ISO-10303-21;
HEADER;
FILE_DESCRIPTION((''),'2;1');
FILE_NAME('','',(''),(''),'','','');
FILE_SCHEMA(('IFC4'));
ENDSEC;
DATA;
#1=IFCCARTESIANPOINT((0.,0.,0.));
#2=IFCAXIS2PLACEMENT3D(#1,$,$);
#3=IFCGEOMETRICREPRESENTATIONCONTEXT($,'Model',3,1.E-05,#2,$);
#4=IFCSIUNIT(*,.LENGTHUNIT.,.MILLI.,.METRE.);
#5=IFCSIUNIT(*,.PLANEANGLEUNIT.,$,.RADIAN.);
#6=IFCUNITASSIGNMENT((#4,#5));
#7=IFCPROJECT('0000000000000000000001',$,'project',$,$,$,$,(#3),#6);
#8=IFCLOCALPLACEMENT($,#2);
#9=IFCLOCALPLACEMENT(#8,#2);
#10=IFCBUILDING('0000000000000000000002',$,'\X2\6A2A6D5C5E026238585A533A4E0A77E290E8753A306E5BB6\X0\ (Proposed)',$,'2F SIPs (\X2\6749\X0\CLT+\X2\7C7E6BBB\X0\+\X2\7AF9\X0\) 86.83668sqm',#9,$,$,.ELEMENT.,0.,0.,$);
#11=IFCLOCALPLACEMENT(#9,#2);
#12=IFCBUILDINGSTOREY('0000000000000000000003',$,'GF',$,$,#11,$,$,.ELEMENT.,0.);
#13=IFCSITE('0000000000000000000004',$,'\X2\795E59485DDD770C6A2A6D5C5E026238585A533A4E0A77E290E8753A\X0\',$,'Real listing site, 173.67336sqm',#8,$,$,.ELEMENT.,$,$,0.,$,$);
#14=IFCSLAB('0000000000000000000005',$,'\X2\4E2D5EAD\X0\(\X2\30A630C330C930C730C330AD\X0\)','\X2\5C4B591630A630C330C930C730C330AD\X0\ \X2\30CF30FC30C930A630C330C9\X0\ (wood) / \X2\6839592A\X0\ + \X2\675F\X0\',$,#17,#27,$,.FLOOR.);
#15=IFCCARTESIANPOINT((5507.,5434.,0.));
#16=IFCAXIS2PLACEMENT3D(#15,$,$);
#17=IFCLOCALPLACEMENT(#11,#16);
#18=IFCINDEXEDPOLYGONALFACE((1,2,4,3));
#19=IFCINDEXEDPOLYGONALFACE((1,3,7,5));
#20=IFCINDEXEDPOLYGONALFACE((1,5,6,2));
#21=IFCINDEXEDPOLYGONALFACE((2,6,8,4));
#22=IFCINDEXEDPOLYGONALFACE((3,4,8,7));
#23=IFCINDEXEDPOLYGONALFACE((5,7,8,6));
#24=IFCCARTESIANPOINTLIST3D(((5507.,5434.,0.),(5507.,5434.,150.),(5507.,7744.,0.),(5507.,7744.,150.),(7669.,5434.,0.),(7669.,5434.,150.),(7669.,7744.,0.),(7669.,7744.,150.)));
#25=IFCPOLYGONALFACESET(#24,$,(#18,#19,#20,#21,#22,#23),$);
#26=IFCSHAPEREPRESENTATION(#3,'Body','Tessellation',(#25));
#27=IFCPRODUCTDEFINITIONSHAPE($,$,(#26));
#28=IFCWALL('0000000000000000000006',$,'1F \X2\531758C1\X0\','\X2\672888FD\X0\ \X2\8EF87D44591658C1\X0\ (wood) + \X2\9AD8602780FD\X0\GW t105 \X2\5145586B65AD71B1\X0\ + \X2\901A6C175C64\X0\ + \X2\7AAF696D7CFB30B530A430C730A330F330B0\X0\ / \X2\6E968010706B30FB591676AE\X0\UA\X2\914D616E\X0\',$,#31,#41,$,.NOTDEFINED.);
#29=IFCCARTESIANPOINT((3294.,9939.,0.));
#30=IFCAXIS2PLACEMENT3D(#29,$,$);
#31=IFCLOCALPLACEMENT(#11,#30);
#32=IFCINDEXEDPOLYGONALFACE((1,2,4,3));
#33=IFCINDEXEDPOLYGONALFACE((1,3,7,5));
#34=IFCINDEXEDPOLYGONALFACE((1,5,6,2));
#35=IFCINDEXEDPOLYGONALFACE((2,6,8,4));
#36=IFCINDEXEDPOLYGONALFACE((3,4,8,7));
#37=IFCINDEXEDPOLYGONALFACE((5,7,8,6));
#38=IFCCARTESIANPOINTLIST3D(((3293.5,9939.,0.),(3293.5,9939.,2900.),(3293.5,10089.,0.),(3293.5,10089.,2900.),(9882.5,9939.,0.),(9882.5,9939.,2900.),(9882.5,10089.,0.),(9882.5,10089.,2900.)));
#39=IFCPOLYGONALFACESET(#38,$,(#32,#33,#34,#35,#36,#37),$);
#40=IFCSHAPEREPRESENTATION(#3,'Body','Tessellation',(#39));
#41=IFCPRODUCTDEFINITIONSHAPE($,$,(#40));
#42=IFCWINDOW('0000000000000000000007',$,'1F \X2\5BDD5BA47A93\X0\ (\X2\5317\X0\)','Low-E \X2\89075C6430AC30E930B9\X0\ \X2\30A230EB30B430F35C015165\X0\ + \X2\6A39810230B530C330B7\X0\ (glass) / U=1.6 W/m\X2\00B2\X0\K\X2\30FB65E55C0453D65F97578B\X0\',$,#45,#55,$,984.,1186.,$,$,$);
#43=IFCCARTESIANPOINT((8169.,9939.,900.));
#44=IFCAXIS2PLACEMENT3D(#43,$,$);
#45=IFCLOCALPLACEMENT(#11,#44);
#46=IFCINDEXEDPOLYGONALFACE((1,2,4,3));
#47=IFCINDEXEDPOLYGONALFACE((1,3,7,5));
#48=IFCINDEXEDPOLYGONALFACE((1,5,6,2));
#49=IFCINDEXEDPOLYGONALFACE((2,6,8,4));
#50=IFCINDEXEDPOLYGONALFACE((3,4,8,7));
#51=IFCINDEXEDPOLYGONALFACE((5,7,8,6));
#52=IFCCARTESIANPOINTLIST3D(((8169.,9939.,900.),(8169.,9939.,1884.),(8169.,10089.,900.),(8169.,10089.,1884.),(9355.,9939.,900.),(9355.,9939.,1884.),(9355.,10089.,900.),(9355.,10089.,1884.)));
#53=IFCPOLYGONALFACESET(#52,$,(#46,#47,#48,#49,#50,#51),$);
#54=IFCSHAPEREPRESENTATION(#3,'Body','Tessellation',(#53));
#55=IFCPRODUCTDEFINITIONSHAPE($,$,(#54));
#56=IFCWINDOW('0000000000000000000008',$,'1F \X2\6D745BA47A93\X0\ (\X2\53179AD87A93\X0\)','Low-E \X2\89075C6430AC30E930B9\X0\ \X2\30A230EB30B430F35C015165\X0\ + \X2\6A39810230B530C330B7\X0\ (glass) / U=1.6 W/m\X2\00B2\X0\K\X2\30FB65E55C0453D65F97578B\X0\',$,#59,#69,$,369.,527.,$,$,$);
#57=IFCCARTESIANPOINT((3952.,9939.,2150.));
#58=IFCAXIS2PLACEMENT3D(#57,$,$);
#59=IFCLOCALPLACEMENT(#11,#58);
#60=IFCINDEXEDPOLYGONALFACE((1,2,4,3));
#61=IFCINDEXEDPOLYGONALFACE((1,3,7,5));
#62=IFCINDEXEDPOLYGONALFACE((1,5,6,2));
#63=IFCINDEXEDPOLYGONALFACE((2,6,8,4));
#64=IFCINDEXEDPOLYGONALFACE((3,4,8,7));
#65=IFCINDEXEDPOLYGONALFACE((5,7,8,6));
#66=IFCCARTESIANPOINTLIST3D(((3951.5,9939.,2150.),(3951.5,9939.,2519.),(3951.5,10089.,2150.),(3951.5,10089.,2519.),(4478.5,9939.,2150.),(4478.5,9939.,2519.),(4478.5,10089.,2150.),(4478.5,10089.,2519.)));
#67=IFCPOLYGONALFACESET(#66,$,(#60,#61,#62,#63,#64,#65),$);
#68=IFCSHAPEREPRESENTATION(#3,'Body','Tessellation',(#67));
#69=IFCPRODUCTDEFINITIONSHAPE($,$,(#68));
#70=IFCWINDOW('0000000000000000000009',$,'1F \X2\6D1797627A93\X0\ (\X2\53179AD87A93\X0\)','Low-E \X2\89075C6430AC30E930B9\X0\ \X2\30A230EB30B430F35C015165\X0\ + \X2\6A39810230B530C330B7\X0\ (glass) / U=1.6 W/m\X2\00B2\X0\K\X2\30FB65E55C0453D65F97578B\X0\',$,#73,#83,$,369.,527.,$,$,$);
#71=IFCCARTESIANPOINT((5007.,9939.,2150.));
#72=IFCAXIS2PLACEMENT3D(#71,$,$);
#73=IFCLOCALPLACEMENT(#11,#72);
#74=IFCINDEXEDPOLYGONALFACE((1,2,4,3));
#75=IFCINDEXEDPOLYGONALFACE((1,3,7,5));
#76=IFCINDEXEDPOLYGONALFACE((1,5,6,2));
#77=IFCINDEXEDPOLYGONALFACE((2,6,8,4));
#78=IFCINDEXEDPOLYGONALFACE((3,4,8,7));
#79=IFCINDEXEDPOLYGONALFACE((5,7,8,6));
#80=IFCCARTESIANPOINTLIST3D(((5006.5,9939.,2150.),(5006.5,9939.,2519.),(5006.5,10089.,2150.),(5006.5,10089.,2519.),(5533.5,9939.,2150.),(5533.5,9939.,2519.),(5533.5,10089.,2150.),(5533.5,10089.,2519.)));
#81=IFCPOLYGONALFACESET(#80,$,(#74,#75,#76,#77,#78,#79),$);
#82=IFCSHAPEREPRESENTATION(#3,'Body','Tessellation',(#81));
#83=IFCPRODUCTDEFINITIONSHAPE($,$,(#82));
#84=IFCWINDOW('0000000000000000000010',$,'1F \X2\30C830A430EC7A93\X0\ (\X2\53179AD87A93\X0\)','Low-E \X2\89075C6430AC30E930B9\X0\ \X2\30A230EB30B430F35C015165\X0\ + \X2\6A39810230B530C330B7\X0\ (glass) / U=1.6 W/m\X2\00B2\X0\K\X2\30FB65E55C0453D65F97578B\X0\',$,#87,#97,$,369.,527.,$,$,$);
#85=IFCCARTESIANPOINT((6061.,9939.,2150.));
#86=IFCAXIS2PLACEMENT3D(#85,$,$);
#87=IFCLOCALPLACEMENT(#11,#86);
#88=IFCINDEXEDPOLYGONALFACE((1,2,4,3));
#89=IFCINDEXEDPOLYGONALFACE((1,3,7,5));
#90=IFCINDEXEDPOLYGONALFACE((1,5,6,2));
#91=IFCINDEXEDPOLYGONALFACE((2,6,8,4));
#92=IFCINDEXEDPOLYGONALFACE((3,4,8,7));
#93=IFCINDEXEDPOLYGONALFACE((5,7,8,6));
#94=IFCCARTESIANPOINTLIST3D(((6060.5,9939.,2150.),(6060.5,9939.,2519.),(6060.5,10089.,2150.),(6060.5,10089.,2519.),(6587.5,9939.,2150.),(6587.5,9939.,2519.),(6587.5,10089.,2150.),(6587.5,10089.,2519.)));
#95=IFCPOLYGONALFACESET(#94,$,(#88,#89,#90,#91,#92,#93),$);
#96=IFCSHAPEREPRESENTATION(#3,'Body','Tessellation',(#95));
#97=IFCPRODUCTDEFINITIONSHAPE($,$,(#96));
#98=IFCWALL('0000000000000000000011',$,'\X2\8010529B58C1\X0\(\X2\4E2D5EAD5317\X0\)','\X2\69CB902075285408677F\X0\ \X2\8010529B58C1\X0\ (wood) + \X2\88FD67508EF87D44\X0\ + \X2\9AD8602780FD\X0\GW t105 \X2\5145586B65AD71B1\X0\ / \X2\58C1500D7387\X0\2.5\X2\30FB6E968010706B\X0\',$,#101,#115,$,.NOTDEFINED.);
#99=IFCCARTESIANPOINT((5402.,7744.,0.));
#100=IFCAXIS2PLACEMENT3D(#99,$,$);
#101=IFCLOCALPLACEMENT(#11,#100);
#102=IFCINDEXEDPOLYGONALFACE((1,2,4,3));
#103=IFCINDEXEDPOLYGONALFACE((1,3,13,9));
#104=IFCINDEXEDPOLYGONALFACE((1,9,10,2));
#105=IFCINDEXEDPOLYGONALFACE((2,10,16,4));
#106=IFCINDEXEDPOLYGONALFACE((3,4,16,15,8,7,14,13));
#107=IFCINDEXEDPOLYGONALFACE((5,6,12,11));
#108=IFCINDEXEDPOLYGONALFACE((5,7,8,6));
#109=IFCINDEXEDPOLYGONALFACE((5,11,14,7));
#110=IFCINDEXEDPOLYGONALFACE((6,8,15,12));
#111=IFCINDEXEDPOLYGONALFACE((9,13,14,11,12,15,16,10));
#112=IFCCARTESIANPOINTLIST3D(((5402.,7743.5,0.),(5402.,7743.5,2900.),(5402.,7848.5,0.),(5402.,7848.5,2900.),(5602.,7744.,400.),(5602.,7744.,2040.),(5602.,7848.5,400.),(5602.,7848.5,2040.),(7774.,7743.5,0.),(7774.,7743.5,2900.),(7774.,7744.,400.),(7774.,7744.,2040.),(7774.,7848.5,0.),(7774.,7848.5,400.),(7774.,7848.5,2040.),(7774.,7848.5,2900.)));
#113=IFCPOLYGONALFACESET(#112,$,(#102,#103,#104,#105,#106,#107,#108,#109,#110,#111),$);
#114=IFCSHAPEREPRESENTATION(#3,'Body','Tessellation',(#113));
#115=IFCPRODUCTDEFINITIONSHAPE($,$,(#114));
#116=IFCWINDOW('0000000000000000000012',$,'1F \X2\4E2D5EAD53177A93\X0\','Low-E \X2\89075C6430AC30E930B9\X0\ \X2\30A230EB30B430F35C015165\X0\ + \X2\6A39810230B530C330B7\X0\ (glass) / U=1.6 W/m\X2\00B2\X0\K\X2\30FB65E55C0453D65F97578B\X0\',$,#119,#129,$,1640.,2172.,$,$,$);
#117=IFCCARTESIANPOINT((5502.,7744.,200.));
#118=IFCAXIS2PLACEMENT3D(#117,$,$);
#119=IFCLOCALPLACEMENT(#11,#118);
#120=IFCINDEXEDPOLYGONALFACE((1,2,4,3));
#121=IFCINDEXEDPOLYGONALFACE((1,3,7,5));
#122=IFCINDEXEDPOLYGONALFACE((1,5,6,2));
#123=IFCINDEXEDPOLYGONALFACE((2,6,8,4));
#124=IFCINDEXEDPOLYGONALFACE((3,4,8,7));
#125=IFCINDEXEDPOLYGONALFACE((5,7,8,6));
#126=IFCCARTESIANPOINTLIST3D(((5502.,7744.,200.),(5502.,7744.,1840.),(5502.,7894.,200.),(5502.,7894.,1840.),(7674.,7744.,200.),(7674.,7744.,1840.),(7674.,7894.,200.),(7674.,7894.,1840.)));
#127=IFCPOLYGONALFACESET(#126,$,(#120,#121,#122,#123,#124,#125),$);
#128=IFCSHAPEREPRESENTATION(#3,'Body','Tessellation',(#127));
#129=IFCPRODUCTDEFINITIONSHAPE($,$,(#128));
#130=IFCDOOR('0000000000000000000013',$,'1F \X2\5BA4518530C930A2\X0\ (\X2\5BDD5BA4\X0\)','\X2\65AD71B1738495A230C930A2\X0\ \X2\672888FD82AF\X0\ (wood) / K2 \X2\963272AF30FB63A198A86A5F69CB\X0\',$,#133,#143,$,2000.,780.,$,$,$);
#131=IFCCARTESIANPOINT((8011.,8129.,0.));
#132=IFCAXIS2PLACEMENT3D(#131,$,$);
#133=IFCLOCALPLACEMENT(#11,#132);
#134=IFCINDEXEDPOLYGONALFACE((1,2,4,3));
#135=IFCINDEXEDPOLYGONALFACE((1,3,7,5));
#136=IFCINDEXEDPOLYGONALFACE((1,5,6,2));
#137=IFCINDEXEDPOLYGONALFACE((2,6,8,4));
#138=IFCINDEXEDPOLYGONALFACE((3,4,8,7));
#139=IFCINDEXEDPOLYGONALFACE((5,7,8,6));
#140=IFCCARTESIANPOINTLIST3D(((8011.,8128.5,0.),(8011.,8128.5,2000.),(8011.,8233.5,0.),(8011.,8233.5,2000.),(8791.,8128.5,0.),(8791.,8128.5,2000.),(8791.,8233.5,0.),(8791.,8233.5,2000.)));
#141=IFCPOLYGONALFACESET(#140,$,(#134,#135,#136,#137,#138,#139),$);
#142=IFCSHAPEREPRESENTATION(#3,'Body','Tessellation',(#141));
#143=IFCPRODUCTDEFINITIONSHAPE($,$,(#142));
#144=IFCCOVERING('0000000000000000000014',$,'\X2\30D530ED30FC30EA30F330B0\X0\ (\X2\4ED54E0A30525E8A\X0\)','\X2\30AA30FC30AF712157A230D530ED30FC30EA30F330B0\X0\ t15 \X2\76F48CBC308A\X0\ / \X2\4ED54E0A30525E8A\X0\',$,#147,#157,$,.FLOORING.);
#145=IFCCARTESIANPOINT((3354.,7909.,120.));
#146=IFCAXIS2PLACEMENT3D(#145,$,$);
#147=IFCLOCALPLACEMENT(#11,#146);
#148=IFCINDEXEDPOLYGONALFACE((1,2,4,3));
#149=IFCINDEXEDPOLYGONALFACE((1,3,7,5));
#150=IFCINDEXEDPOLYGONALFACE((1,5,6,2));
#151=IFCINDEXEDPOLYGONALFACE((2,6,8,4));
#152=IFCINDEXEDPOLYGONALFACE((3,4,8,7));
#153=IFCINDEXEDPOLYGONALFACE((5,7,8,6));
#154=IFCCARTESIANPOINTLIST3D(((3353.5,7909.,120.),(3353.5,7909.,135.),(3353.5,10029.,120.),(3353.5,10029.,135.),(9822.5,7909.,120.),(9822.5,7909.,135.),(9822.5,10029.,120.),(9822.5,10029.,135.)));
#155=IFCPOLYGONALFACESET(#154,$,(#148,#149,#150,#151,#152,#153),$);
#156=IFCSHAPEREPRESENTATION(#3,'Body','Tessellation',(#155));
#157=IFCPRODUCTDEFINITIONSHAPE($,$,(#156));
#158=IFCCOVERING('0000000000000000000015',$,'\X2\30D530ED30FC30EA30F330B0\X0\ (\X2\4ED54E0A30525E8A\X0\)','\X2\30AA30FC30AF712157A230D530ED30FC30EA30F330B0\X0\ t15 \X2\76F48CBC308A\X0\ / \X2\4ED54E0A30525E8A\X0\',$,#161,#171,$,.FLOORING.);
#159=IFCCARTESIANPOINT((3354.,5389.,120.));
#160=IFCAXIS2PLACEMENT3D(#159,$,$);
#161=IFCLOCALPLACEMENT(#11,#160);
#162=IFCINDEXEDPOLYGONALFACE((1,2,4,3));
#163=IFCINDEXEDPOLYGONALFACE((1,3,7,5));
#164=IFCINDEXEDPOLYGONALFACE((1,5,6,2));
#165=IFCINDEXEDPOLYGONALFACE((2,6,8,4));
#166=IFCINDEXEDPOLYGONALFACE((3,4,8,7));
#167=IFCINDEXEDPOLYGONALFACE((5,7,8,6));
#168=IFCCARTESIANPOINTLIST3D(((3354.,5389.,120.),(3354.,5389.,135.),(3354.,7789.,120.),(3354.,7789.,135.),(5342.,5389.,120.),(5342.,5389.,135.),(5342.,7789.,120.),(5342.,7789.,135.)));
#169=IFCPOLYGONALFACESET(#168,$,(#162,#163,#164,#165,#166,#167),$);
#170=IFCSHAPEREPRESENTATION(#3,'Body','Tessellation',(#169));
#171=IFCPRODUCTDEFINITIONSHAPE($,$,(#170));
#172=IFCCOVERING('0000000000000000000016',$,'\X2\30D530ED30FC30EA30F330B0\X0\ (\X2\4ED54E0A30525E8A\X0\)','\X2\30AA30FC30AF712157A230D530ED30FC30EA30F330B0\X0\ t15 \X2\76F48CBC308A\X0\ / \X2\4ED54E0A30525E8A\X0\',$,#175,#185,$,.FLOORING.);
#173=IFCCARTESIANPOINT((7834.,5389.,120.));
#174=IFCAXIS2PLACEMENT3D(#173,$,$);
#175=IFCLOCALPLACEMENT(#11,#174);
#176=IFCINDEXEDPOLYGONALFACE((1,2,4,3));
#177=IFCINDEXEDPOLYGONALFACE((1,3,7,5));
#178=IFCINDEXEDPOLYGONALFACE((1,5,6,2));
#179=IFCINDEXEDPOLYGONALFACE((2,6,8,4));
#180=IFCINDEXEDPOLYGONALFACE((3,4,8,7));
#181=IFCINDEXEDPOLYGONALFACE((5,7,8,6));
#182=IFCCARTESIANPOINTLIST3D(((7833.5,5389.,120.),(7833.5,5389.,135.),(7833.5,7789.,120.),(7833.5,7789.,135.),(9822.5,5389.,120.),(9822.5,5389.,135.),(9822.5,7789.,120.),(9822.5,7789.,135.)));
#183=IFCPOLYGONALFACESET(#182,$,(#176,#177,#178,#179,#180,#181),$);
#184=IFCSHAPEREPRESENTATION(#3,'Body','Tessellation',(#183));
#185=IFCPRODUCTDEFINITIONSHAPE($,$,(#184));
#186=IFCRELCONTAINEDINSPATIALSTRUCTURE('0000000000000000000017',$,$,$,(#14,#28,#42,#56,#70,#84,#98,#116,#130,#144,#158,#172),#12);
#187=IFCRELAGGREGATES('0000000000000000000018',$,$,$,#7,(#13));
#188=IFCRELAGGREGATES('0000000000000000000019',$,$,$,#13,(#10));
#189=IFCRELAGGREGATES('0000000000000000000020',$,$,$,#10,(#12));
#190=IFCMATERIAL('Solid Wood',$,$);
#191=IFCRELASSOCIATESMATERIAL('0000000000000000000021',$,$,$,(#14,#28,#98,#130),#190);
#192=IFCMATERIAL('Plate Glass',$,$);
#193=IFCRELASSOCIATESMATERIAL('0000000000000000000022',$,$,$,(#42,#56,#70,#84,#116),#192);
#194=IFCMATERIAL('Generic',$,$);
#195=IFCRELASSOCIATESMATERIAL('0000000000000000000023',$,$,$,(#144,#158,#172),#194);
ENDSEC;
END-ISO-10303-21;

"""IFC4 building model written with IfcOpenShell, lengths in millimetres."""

from ifc_helpers import new_model, si_unit, frame, frame_2d, origin, place, context, project, spatial, rectangle, extrude, material, element, fill, save


model = new_model("IFC4")

# Units and contexts
model_context = context("Model", 3, precision=1e-05, world=origin())
ifc_project = project(units=[si_unit("LENGTHUNIT", "METRE", prefix="MILLI"), si_unit("PLANEANGLEUNIT", "RADIAN")], contexts=[model_context])

# Site, building, storey
site_placement = place(None, origin())
site = spatial("IfcSite", under=ifc_project, at=site_placement, Name="神奈川県横浜市戸塚区上矢部町", ObjectType="Real listing site, 173.67336sqm", CompositionType="ELEMENT", RefElevation=0.0)
building_placement = place(site_placement, origin())
building = spatial("IfcBuilding", under=site, at=building_placement, Name="横浜市戸塚区上矢部町の家 (Proposed)", ObjectType="2F SIPs (杉CLT+籾殻+竹) 86.83668sqm", CompositionType="ELEMENT", ElevationOfRefHeight=0.0, ElevationOfTerrain=0.0)
storey_placement = place(building_placement, origin())
storey = spatial("IfcBuildingStorey", under=building, at=storey_placement, Name="GF", CompositionType="ELEMENT", Elevation=0.0)

# Slab
ifc_material_1 = material(Name="Solid Wood")
slab_1_placement = place(storey_placement, frame((5507.0, 5434.0, 0.0)))
element("IfcSlab", 1, at=slab_1_placement, inside=storey, material=ifc_material_1, Name="中庭(ウッドデッキ)", Description="屋外ウッドデッキ ハードウッド (wood) / 根太 + 束", PredefinedType="FLOOR", context=model_context, shape_type="SweptSolid", body=[
    extrude(rectangle(XDim=2162.0, YDim=2310.0, at=frame_2d((1081.0, 1155.0))), frame((5507.0, 5434.0, 0.0)), (0.0, 0.0, 1.0), 150.0),
])

# Wall, openings, windows
wall_1_placement = place(storey_placement, frame((3294.0, 9939.0, 0.0)))
wall_1 = element("IfcWall", 2, at=wall_1_placement, inside=storey, material=ifc_material_1, Name="1F 北壁", Description="木製 軸組外壁 (wood) + 高性能GW t105 充填断熱 + 通気層 + 窯業系サイディング / 準耐火・外皮UA配慮", PredefinedType="NOTDEFINED", context=model_context, shape_type="SweptSolid", body=[
    extrude(rectangle(XDim=6589.0, YDim=150.0, at=frame_2d((3294.0, 75.0))), frame((3294.0, 9939.0, 0.0)), (0.0, 0.0, 1.0), 2900.0),
])
opening_1_placement = place(storey_placement, frame((8169.0, 9939.0, 900.0)))
opening_1 = element("IfcOpeningElement", 3, at=opening_1_placement, cuts=wall_1, PredefinedType="NOTDEFINED", context=model_context, shape_type="SweptSolid", body=[
    extrude(rectangle(XDim=1186.0, YDim=150.0, at=frame_2d((593.0, 75.0))), frame((8169.0, 9939.0, 900.0)), (0.0, 0.0, 1.0), 984.0),
])
opening_2_placement = place(storey_placement, frame((3952.0, 9939.0, 2150.0)))
opening_2 = element("IfcOpeningElement", 4, at=opening_2_placement, cuts=wall_1, PredefinedType="NOTDEFINED", context=model_context, shape_type="SweptSolid", body=[
    extrude(rectangle(XDim=527.0, YDim=150.0, at=frame_2d((263.0, 75.0))), frame((3952.0, 9939.0, 2150.0)), (0.0, 0.0, 1.0), 369.0),
])
opening_3_placement = place(storey_placement, frame((5007.0, 9939.0, 2150.0)))
opening_3 = element("IfcOpeningElement", 5, at=opening_3_placement, cuts=wall_1, PredefinedType="NOTDEFINED", context=model_context, shape_type="SweptSolid", body=[
    extrude(rectangle(XDim=527.0, YDim=150.0, at=frame_2d((263.0, 75.0))), frame((5007.0, 9939.0, 2150.0)), (0.0, 0.0, 1.0), 369.0),
])
opening_4_placement = place(storey_placement, frame((6061.0, 9939.0, 2150.0)))
opening_4 = element("IfcOpeningElement", 6, at=opening_4_placement, cuts=wall_1, PredefinedType="NOTDEFINED", context=model_context, shape_type="SweptSolid", body=[
    extrude(rectangle(XDim=527.0, YDim=150.0, at=frame_2d((263.0, 75.0))), frame((6061.0, 9939.0, 2150.0)), (0.0, 0.0, 1.0), 369.0),
])
ifc_material_2 = material(Name="Plate Glass")
window_1_placement = place(storey_placement, frame((8169.0, 9939.0, 900.0)))
window_1 = element("IfcWindow", 7, at=window_1_placement, inside=storey, material=ifc_material_2, Name="1F 寝室窓 (北)", Description="Low-E 複層ガラス アルゴン封入 + 樹脂サッシ (glass) / U=1.6 W/m²K・日射取得型", OverallHeight=984.0, OverallWidth=1186.0, context=model_context, shape_type="SweptSolid", body=[
    extrude(rectangle(XDim=1186.0, YDim=150.0, at=frame_2d((593.0, 75.0))), frame((8169.0, 9939.0, 900.0)), (0.0, 0.0, 1.0), 984.0),
])
fill(opening_1, window_1)
window_2_placement = place(storey_placement, frame((3952.0, 9939.0, 2150.0)))
window_2 = element("IfcWindow", 8, at=window_2_placement, inside=storey, material=ifc_material_2, Name="1F 浴室窓 (北高窓)", Description="Low-E 複層ガラス アルゴン封入 + 樹脂サッシ (glass) / U=1.6 W/m²K・日射取得型", OverallHeight=369.0, OverallWidth=527.0, context=model_context, shape_type="SweptSolid", body=[
    extrude(rectangle(XDim=527.0, YDim=150.0, at=frame_2d((263.0, 75.0))), frame((3952.0, 9939.0, 2150.0)), (0.0, 0.0, 1.0), 369.0),
])
fill(opening_2, window_2)
window_3_placement = place(storey_placement, frame((5007.0, 9939.0, 2150.0)))
window_3 = element("IfcWindow", 9, at=window_3_placement, inside=storey, material=ifc_material_2, Name="1F 洗面窓 (北高窓)", Description="Low-E 複層ガラス アルゴン封入 + 樹脂サッシ (glass) / U=1.6 W/m²K・日射取得型", OverallHeight=369.0, OverallWidth=527.0, context=model_context, shape_type="SweptSolid", body=[
    extrude(rectangle(XDim=527.0, YDim=150.0, at=frame_2d((263.0, 75.0))), frame((5007.0, 9939.0, 2150.0)), (0.0, 0.0, 1.0), 369.0),
])
fill(opening_3, window_3)
window_4_placement = place(storey_placement, frame((6061.0, 9939.0, 2150.0)))
window_4 = element("IfcWindow", 10, at=window_4_placement, inside=storey, material=ifc_material_2, Name="1F トイレ窓 (北高窓)", Description="Low-E 複層ガラス アルゴン封入 + 樹脂サッシ (glass) / U=1.6 W/m²K・日射取得型", OverallHeight=369.0, OverallWidth=527.0, context=model_context, shape_type="SweptSolid", body=[
    extrude(rectangle(XDim=527.0, YDim=150.0, at=frame_2d((263.0, 75.0))), frame((6061.0, 9939.0, 2150.0)), (0.0, 0.0, 1.0), 369.0),
])
fill(opening_4, window_4)

# Wall, opening, window
wall_2_placement = place(storey_placement, frame((5402.0, 7744.0, 0.0)))
wall_2 = element("IfcWall", 11, at=wall_2_placement, inside=storey, material=ifc_material_1, Name="耐力壁(中庭北)", Description="構造用合板 耐力壁 (wood) + 製材軸組 + 高性能GW t105 充填断熱 / 壁倍率2.5・準耐火", PredefinedType="NOTDEFINED", context=model_context, shape_type="SweptSolid", body=[
    extrude(rectangle(XDim=2372.0, YDim=105.0, at=frame_2d((1186.0, 52.0))), frame((5402.0, 7744.0, 0.0)), (0.0, 0.0, 1.0), 2900.0),
])
opening_5_placement = place(storey_placement, frame((5502.0, 7744.0, 200.0)))
opening_5 = element("IfcOpeningElement", 12, at=opening_5_placement, cuts=wall_2, PredefinedType="NOTDEFINED", context=model_context, shape_type="SweptSolid", body=[
    extrude(rectangle(XDim=2172.0, YDim=150.0, at=frame_2d((1086.0, 75.0))), frame((5502.0, 7744.0, 200.0)), (0.0, 0.0, 1.0), 1640.0),
])
window_5_placement = place(storey_placement, frame((5502.0, 7744.0, 200.0)))
window_5 = element("IfcWindow", 13, at=window_5_placement, inside=storey, material=ifc_material_2, Name="1F 中庭北窓", Description="Low-E 複層ガラス アルゴン封入 + 樹脂サッシ (glass) / U=1.6 W/m²K・日射取得型", OverallHeight=1640.0, OverallWidth=2172.0, context=model_context, shape_type="SweptSolid", body=[
    extrude(rectangle(XDim=2172.0, YDim=150.0, at=frame_2d((1086.0, 75.0))), frame((5502.0, 7744.0, 200.0)), (0.0, 0.0, 1.0), 1640.0),
])
fill(opening_5, window_5)

# Door
door_1_placement = place(storey_placement, frame((8011.0, 8129.0, 0.0)))
element("IfcDoor", 14, at=door_1_placement, inside=storey, material=ifc_material_1, Name="1F 室内ドア (寝室)", Description="断熱玄関ドア 木製芯 (wood) / K2 防犯・採風機構", OverallHeight=2000.0, OverallWidth=780.0, context=model_context, shape_type="SweptSolid", body=[
    extrude(rectangle(XDim=780.0, YDim=105.0, at=frame_2d((390.0, 52.0))), frame((8011.0, 8129.0, 0.0)), (0.0, 0.0, 1.0), 2000.0),
])

# Coverings
ifc_material_3 = material(Name="Generic")
covering_1_placement = place(storey_placement, frame((3354.0, 7909.0, 120.0)))
element("IfcCovering", 15, at=covering_1_placement, inside=storey, material=ifc_material_3, Name="フローリング (仕上げ床)", Description="オーク無垢フローリング t15 直貼り / 仕上げ床", PredefinedType="FLOORING", context=model_context, shape_type="SweptSolid", body=[
    extrude(rectangle(XDim=6469.0, YDim=2120.0, at=frame_2d((3234.0, 1060.0))), frame((3354.0, 7909.0, 120.0)), (0.0, 0.0, 1.0), 15.0),
])
covering_2_placement = place(storey_placement, frame((3354.0, 5389.0, 120.0)))
element("IfcCovering", 16, at=covering_2_placement, inside=storey, material=ifc_material_3, Name="フローリング (仕上げ床)", Description="オーク無垢フローリング t15 直貼り / 仕上げ床", PredefinedType="FLOORING", context=model_context, shape_type="SweptSolid", body=[
    extrude(rectangle(XDim=1988.0, YDim=2400.0, at=frame_2d((994.0, 1200.0))), frame((3354.0, 5389.0, 120.0)), (0.0, 0.0, 1.0), 15.0),
])
covering_3_placement = place(storey_placement, frame((7834.0, 5389.0, 120.0)))
element("IfcCovering", 17, at=covering_3_placement, inside=storey, material=ifc_material_3, Name="フローリング (仕上げ床)", Description="オーク無垢フローリング t15 直貼り / 仕上げ床", PredefinedType="FLOORING", context=model_context, shape_type="SweptSolid", body=[
    extrude(rectangle(XDim=1989.0, YDim=2400.0, at=frame_2d((994.0, 1200.0))), frame((7834.0, 5389.0, 120.0)), (0.0, 0.0, 1.0), 15.0),
])

save(model, "model.ifc")
